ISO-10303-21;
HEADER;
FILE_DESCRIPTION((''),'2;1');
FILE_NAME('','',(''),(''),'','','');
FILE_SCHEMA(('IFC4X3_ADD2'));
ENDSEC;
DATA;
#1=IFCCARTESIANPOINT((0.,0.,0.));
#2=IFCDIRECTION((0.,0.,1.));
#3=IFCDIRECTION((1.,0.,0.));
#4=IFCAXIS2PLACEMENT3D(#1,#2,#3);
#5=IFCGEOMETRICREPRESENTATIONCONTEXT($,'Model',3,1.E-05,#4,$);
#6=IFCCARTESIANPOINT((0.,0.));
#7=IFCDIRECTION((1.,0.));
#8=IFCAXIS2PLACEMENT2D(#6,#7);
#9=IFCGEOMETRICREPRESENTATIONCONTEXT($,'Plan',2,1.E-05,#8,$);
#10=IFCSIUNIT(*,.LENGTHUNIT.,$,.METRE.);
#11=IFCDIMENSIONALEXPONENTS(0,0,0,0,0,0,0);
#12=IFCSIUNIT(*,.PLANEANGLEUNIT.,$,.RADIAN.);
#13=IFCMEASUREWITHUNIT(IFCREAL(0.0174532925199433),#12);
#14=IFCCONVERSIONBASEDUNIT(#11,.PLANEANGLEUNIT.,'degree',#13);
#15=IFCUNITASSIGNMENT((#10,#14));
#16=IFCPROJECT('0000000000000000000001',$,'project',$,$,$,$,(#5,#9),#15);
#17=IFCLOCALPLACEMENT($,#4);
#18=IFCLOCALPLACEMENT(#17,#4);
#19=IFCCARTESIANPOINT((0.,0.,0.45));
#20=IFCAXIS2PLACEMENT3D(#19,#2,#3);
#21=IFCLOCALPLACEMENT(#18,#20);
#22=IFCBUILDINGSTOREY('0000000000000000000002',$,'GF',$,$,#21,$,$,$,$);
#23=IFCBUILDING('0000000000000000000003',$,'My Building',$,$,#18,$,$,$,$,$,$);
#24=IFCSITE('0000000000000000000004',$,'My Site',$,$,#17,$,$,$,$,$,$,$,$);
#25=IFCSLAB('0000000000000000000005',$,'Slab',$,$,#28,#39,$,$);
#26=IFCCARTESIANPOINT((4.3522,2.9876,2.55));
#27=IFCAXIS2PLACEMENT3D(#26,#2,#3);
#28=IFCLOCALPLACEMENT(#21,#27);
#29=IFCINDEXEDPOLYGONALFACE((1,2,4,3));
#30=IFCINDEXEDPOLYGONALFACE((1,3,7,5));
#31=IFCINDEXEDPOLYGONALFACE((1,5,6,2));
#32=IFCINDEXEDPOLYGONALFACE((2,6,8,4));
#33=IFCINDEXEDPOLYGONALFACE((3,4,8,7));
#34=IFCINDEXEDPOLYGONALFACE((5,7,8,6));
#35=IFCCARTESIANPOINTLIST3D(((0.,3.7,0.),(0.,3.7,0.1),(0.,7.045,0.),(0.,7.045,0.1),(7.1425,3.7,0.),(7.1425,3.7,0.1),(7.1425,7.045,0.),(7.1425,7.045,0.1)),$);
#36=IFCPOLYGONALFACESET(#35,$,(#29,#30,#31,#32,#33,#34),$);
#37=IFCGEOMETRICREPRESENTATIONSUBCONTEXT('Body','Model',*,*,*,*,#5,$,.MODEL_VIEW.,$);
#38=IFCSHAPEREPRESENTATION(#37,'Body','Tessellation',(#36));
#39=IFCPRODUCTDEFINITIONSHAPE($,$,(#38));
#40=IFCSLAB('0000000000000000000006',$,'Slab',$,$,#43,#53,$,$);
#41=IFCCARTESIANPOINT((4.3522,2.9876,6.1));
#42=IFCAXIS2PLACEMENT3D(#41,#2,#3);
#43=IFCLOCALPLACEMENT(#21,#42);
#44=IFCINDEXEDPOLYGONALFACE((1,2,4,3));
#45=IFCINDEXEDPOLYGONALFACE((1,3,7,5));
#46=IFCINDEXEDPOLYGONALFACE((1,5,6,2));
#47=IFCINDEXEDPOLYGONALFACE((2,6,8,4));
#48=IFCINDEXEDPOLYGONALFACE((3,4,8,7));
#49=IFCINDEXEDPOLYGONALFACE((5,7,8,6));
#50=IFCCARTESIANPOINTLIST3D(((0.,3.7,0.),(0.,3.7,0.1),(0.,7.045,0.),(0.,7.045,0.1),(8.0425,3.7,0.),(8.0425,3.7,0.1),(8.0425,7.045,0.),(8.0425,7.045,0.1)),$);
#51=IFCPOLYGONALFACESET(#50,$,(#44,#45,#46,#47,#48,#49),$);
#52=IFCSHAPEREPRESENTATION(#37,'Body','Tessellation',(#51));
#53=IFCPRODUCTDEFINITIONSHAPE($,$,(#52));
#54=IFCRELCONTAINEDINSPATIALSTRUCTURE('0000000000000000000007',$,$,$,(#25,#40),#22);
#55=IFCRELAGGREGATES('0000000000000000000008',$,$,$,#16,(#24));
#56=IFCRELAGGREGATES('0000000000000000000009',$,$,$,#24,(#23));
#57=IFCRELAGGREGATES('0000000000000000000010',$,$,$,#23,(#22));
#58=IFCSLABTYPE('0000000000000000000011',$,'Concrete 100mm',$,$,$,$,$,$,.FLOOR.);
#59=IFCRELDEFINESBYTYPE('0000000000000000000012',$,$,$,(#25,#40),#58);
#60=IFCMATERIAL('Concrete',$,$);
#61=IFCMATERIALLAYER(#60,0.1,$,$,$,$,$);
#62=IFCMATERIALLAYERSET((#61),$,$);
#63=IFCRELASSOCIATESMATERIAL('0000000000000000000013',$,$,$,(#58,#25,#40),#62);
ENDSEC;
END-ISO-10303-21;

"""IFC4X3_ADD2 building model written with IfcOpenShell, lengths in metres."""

from ifc_helpers import new_model, entity, si_unit, converted_unit, frame, origin_with_axes, origin_2d_with_axis, place, context, subcontext, project, spatial, indexed_curve, outline, extrude, material, layer, layer_set, layer_usage, type_object, element, save


model = new_model("IFC4X3_ADD2")

# Units and contexts
model_context = context("Model", 3, precision=1e-05, world=origin_with_axes())
plan_context = context("Plan", 2, precision=1e-05, world=origin_2d_with_axis())
body_context_1 = subcontext(model_context, "Body", "Model", "MODEL_VIEW")
ifc_project = project(units=[si_unit("LENGTHUNIT", "METRE"), converted_unit("PLANEANGLEUNIT", "degree", entity("IfcReal", 0.0174532925199433), si_unit("PLANEANGLEUNIT", "RADIAN"), dimensions=[0, 0, 0, 0, 0, 0, 0])], contexts=[model_context, plan_context])

# Site, building, storey
site_placement = place(None, origin_with_axes())
site = spatial("IfcSite", under=ifc_project, at=site_placement, Name="My Site")
building_placement = place(site_placement, origin_with_axes())
building = spatial("IfcBuilding", under=site, at=building_placement, Name="My Building")
storey_placement = place(building_placement, frame((0.0, 0.0, 0.45), z_axis=(0.0, 0.0, 1.0), x_axis=(1.0, 0.0, 0.0)))
storey = spatial("IfcBuildingStorey", under=building, at=storey_placement, Name="GF")

# Slabs
ifc_material_1 = material(Name="Concrete")
ifc_layer_1 = layer(ifc_material_1, 0.1)
ifc_layer_set_1 = layer_set([ifc_layer_1])
ifc_layer_usage_1 = layer_usage(ifc_layer_set_1, "AXIS3", "POSITIVE", 0.0)
slab_type_1 = type_object("IfcSlabType", Name="Concrete 100mm", PredefinedType="FLOOR", material=ifc_layer_set_1)
slab_1_placement = place(storey_placement, frame((4.3522, 2.9876, 2.55), z_axis=(0.0, 0.0, 1.0), x_axis=(1.0, 0.0, 0.0)))
element("IfcSlab", 1, at=slab_1_placement, inside=storey, type_object=slab_type_1, material=ifc_layer_usage_1, Name="Slab", context=body_context_1, shape_type="SolidModel", body=[
    extrude(outline(indexed_curve([(0.0, 7.045), (7.1425, 7.045), (7.1425, 3.7), (0.0, 3.7), (0.0, 7.045)])), origin_with_axes(), (0.0, 0.0, 1.0), 0.1),
])
ifc_layer_usage_2 = layer_usage(ifc_layer_set_1, "AXIS3", "POSITIVE", 0.0)
slab_2_placement = place(storey_placement, frame((4.3522, 2.9876, 6.1), z_axis=(0.0, 0.0, 1.0), x_axis=(1.0, 0.0, 0.0)))
element("IfcSlab", 2, at=slab_2_placement, inside=storey, type_object=slab_type_1, material=ifc_layer_usage_2, Name="Slab", context=body_context_1, shape_type="SolidModel", body=[
    extrude(outline(indexed_curve([(0.0, 3.7), (8.0425, 3.7), (8.0425, 7.045), (0.0, 7.045), (0.0, 3.7)])), origin_with_axes(), (0.0, 0.0, 1.0), 0.1),
])

save(model, "model.ifc")
